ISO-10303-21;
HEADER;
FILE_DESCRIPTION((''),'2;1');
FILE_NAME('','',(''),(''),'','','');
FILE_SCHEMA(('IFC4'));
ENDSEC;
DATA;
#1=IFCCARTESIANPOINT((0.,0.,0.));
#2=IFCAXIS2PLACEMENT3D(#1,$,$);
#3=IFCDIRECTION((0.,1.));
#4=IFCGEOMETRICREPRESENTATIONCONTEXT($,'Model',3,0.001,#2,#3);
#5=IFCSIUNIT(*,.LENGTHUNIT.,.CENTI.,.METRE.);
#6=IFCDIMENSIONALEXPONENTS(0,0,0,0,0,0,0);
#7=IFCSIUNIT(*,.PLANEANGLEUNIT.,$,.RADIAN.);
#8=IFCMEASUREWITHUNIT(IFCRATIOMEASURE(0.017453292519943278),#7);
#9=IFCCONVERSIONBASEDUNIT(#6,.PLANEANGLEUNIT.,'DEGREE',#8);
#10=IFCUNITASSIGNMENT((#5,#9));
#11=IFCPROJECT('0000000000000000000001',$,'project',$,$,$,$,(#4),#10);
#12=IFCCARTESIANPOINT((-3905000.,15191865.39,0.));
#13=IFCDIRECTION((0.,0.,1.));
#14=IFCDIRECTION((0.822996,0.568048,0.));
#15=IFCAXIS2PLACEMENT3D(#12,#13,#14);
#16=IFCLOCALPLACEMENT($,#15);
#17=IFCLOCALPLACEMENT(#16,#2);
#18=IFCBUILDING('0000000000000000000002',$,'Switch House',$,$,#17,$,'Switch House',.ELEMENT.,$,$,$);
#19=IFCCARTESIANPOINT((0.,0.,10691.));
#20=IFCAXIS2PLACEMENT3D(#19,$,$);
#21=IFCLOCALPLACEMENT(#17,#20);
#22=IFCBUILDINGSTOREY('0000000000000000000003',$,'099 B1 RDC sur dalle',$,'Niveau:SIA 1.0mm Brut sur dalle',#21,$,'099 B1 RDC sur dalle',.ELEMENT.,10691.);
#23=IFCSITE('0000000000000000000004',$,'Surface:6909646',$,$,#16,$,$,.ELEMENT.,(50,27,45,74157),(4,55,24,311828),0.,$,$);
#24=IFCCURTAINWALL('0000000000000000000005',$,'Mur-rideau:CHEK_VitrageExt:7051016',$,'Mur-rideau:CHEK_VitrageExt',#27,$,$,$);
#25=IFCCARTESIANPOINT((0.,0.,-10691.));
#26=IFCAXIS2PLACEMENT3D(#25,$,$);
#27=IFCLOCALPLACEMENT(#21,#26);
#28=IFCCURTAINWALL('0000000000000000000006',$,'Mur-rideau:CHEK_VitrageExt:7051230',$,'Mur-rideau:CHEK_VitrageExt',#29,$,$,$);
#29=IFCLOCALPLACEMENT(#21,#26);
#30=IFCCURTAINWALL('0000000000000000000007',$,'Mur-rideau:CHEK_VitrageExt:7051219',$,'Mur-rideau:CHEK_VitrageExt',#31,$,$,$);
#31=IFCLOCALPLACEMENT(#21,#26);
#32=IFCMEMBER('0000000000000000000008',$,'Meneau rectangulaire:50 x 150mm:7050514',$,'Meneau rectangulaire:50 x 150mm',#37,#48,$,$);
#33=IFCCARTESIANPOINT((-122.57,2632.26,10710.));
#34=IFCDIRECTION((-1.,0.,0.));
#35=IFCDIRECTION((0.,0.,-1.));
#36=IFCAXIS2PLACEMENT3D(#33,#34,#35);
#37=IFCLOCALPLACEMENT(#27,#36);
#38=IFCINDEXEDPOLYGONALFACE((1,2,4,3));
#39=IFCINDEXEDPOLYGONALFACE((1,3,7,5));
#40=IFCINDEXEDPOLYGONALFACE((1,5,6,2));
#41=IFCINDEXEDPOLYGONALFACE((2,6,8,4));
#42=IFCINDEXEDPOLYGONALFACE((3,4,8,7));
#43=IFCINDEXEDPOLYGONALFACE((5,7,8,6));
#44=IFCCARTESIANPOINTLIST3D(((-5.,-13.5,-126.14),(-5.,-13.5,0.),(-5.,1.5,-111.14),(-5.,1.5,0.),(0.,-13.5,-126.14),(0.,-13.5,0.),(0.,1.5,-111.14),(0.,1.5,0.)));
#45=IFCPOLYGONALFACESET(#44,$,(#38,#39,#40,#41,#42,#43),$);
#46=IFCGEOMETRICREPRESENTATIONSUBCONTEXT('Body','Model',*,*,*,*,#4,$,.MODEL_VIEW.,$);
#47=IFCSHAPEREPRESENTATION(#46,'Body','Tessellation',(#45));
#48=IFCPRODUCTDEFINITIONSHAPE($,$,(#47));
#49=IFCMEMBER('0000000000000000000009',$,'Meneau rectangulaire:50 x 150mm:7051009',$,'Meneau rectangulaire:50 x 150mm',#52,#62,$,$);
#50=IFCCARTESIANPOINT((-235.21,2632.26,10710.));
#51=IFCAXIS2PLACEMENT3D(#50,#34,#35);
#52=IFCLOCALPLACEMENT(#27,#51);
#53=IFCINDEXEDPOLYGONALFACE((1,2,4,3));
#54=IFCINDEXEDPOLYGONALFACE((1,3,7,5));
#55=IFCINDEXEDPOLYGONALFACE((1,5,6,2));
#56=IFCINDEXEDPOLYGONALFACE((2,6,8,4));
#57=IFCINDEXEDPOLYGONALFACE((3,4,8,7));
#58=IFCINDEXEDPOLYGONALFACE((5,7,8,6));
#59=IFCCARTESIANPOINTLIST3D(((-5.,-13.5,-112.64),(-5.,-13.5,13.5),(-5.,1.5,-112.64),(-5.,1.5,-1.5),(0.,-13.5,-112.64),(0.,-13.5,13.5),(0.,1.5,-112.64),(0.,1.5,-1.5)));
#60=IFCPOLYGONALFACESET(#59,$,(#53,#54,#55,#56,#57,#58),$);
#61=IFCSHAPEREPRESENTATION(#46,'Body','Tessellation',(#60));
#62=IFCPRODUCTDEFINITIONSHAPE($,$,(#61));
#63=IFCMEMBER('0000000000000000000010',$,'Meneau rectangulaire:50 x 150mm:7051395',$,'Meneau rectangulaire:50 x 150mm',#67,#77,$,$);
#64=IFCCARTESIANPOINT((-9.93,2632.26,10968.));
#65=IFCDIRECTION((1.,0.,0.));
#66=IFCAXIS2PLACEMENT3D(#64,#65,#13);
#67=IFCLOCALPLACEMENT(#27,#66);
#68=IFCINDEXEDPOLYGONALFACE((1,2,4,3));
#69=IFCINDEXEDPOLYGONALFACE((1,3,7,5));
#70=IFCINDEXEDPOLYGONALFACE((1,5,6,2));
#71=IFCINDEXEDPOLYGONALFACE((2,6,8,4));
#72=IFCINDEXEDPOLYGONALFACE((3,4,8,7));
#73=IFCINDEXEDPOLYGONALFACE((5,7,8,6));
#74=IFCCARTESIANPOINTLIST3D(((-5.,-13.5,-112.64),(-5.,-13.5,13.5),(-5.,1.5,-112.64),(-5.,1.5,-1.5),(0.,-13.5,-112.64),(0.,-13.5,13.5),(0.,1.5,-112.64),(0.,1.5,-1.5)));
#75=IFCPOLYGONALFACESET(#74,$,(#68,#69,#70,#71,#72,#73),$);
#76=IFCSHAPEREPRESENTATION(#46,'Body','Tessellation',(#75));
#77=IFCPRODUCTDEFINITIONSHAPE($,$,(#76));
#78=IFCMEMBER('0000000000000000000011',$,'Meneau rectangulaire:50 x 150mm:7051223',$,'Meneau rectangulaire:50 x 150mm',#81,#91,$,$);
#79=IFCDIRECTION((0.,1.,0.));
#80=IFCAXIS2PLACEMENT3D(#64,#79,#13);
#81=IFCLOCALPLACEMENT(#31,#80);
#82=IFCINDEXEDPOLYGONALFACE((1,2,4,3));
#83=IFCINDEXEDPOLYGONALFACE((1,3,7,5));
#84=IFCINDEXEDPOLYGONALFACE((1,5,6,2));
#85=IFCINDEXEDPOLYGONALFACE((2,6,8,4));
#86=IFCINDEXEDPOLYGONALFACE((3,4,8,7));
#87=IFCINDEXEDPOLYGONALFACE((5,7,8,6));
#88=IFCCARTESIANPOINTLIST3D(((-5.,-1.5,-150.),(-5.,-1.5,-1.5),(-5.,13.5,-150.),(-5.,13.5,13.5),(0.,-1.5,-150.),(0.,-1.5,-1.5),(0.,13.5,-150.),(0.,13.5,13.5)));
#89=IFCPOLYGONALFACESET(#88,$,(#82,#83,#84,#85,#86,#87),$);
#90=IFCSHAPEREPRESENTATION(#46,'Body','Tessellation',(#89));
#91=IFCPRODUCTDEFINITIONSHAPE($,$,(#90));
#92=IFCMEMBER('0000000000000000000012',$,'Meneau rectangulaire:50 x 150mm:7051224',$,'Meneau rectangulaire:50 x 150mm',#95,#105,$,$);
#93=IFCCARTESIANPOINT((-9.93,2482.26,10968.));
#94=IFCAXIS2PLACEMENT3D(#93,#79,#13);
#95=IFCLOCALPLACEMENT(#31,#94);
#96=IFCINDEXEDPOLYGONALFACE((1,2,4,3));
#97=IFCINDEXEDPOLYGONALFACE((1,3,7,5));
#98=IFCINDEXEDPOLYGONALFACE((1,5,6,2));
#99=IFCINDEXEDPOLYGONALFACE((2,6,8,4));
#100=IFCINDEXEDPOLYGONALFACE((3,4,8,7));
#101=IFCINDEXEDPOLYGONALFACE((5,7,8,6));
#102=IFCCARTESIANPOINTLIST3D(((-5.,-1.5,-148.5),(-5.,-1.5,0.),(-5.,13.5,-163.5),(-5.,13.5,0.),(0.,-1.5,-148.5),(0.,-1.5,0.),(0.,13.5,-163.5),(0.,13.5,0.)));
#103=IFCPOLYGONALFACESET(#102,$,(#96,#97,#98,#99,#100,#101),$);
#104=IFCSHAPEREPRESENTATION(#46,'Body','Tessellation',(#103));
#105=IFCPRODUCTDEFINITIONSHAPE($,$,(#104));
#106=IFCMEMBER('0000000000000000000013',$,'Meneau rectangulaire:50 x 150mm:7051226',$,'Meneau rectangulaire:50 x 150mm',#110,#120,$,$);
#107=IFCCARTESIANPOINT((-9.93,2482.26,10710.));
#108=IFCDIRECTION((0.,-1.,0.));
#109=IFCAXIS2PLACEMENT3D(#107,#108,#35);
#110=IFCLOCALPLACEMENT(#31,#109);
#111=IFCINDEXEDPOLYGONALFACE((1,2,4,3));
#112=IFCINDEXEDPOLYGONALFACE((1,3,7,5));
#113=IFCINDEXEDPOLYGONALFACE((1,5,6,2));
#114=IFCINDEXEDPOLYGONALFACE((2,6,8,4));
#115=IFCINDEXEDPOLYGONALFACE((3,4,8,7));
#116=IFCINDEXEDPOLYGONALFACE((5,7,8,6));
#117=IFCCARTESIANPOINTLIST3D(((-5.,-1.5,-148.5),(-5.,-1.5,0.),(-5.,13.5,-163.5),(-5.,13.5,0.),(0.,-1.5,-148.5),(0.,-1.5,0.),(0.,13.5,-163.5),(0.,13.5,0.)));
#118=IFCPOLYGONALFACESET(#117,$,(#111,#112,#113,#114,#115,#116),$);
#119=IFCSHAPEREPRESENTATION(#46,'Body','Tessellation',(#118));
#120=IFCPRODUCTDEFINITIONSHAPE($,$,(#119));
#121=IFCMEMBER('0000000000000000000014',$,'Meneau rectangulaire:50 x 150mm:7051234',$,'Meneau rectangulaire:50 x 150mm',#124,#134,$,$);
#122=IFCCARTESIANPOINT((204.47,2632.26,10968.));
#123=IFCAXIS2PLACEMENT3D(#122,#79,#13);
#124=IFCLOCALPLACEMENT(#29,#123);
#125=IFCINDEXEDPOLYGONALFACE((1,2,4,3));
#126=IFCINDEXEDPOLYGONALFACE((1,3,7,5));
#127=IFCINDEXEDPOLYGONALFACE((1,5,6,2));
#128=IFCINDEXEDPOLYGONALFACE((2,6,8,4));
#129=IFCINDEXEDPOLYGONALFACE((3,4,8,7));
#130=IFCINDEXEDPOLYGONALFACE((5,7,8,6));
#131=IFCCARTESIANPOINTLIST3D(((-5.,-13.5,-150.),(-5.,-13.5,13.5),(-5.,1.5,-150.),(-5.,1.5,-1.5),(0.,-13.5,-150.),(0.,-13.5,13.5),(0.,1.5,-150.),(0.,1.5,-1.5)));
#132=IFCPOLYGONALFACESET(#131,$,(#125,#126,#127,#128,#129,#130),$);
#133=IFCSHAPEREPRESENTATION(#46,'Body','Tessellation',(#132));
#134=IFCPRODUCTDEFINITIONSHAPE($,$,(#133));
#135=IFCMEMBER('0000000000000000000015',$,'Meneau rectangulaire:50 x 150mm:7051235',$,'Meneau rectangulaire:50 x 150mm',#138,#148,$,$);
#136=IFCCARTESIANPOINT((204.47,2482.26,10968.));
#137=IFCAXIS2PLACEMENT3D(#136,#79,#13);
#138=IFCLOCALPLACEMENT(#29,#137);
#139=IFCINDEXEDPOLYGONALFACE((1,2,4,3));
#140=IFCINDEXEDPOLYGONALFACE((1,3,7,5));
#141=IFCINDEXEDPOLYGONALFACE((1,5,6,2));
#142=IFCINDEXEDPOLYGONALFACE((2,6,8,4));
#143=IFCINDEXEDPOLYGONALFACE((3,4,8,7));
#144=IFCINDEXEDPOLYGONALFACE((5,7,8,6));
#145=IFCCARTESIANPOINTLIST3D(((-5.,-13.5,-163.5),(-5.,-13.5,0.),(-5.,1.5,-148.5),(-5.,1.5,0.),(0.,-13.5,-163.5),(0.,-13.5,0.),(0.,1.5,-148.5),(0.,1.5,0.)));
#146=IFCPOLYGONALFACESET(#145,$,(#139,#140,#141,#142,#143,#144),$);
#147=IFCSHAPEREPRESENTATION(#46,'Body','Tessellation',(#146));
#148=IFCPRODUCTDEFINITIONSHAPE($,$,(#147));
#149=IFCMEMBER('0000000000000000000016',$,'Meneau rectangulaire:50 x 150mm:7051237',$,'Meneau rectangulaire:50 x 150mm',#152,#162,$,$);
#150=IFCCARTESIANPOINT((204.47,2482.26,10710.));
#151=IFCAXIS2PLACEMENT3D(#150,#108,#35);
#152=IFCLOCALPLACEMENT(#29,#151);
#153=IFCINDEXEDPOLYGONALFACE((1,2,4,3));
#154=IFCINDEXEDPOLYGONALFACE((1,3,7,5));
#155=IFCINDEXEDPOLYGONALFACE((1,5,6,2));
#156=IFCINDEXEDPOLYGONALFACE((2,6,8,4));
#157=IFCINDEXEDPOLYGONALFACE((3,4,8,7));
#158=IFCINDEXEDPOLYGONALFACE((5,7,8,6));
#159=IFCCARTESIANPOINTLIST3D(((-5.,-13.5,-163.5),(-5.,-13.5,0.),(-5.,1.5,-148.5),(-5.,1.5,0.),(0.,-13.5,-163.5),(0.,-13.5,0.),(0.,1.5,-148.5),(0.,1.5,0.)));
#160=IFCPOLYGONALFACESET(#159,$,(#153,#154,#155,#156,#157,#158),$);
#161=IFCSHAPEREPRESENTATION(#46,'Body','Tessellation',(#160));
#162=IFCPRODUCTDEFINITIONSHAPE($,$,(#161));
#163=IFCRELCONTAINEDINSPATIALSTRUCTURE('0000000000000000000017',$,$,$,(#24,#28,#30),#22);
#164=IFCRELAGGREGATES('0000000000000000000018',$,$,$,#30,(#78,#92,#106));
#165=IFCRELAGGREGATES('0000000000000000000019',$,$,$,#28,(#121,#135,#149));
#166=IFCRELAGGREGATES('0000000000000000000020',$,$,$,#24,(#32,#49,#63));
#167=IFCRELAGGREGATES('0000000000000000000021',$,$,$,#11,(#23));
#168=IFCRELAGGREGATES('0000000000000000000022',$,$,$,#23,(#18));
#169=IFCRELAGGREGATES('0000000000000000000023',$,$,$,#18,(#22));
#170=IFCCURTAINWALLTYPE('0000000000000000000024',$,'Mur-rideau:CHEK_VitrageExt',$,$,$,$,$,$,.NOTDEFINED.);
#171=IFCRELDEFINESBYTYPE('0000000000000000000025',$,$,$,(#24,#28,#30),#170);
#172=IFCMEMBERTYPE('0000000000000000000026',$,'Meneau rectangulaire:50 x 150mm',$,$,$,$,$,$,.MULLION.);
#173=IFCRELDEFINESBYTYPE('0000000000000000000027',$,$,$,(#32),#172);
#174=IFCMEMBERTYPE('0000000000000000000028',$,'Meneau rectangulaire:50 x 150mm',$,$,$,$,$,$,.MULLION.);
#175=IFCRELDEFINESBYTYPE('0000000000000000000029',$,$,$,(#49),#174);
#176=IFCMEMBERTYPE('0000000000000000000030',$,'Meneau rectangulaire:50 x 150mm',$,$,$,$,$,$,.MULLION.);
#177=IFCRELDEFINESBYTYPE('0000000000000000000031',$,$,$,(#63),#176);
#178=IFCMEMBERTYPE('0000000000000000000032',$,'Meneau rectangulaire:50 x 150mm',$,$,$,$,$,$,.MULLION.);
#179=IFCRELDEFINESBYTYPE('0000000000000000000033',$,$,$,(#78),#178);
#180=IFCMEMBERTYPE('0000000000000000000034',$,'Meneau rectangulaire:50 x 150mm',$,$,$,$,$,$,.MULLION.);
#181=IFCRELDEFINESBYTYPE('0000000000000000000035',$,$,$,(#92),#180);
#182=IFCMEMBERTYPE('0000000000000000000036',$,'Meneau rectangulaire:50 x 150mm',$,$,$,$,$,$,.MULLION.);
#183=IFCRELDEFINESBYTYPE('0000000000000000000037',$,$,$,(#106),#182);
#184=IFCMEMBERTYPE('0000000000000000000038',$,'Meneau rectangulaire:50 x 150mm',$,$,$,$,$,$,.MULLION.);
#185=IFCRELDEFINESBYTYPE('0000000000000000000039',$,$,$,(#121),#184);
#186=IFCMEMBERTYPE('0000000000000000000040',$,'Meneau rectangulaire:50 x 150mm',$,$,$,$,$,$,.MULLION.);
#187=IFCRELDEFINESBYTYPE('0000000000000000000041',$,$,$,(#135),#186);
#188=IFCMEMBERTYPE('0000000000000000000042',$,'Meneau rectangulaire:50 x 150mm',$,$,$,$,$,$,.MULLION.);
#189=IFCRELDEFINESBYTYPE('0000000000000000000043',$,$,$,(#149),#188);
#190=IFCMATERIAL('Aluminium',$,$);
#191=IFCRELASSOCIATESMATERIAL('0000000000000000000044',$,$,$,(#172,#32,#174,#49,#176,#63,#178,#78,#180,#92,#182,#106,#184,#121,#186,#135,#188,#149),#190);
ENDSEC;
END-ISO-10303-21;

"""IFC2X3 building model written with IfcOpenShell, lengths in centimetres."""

from ifc_helpers import new_model, entity, si_unit, converted_unit, direction, frame, origin, origin_2d_with_axis, place, context, subcontext, project, spatial, rectangle, extrude, clip, halfspace, source, transform, mapped, material, type_object, type_shapes, element, aggregate, save


model = new_model("IFC2X3")

# Units and contexts
model_context = context("Model", 3, precision=0.001, world=origin(), true_north=direction((0.0, 1.0)))
body_context = subcontext(model_context, "Body", "Model", "MODEL_VIEW")
ifc_project = project(units=[si_unit("LENGTHUNIT", "METRE", prefix="CENTI"), converted_unit("PLANEANGLEUNIT", "DEGREE", entity("IfcRatioMeasure", 0.017453292519943278), si_unit("PLANEANGLEUNIT", "RADIAN"), dimensions=[0, 0, 0, 0, 0, 0, 0])], contexts=[model_context])

# Site, building, storey
site_placement = place(None, frame((-3905000.0, 15191865.39, 0.0), z_axis=(0.0, 0.0, 1.0), x_axis=(0.822996, 0.568048, 0.0)))
site = spatial("IfcSite", under=ifc_project, at=site_placement, Name="Surface:6909646", CompositionType="ELEMENT", RefLatitude=(50, 27, 45, 74157), RefLongitude=(4, 55, 24, 311828), RefElevation=0.0)
building_placement = place(site_placement, origin())
building = spatial("IfcBuilding", under=site, at=building_placement, Name="Switch House", LongName="Switch House", CompositionType="ELEMENT")
storey_placement = place(building_placement, frame((0.0, 0.0, 10691.0)))
storey = spatial("IfcBuildingStorey", under=building, at=storey_placement, Name="099 B1 RDC sur dalle", ObjectType="Niveau:SIA 1.0mm Brut sur dalle", LongName="099 B1 RDC sur dalle", CompositionType="ELEMENT", Elevation=10691.0)

# Curtain wall
curtain_wall_type = type_object("IfcCurtainWallType", Name="Mur-rideau:CHEK_VitrageExt", PredefinedType="NOTDEFINED")
curtain_wall_1_placement = place(storey_placement, frame((0.0, 0.0, -10691.0)))
curtain_wall_1 = element("IfcCurtainWall", 1, at=curtain_wall_1_placement, inside=storey, type_object=curtain_wall_type, Name="Mur-rideau:CHEK_VitrageExt:7051016", ObjectType="Mur-rideau:CHEK_VitrageExt")
ifc_material_1 = material(Name="Aluminium")

# Curtain wall
curtain_wall_2_placement = place(storey_placement, frame((0.0, 0.0, -10691.0)))
curtain_wall_2 = element("IfcCurtainWall", 2, at=curtain_wall_2_placement, inside=storey, type_object=curtain_wall_type, Name="Mur-rideau:CHEK_VitrageExt:7051230", ObjectType="Mur-rideau:CHEK_VitrageExt")

# Curtain wall
curtain_wall_3_placement = place(storey_placement, frame((0.0, 0.0, -10691.0)))
curtain_wall_3 = element("IfcCurtainWall", 3, at=curtain_wall_3_placement, inside=storey, type_object=curtain_wall_type, Name="Mur-rideau:CHEK_VitrageExt:7051219", ObjectType="Mur-rideau:CHEK_VitrageExt")

# Members
member_type_1 = type_object("IfcMemberType", Name="Meneau rectangulaire:50 x 150mm", PredefinedType="MULLION", material=ifc_material_1)
shared_shape_1 = source(origin(), body_context, "Body", "SweptSolid", [
    clip(extrude(rectangle(XDim=15.0, YDim=5.0, at=origin_2d_with_axis()), frame((-2.5, -6.0, -126.14), z_axis=(0.0, 0.0, 1.0), x_axis=(0.0, -1.0, 0.0)), (0.0, 0.0, 1.0), 126.14), halfspace(frame((-30.48, 0.0, -112.64), z_axis=(0.0, 0.707107, -0.707107), x_axis=(0.0, 0.707107, 0.707107)), False)),
])
type_shapes(member_type_1, [shared_shape_1])
member_1_placement = place(curtain_wall_1_placement, frame((-122.57, 2632.26, 10710.0), z_axis=(-1.0, 0.0, 0.0), x_axis=(0.0, 0.0, -1.0)))
member_1 = element("IfcMember", 4, at=member_1_placement, type_object=member_type_1, material=ifc_material_1, Name="Meneau rectangulaire:50 x 150mm:7050514", ObjectType="Meneau rectangulaire:50 x 150mm", context=body_context, shape_type="MappedRepresentation", body=[
    mapped(shared_shape_1, transform((0.0, 0.0, 0.0), scale=1.0)),
])
member_type_2 = type_object("IfcMemberType", Name="Meneau rectangulaire:50 x 150mm", PredefinedType="MULLION", material=ifc_material_1)
shared_shape_2 = source(origin(), body_context, "Body", "SweptSolid", [
    clip(extrude(rectangle(XDim=15.0, YDim=5.0, at=origin_2d_with_axis()), frame((-2.5, -6.0, -112.64), z_axis=(0.0, 0.0, 1.0), x_axis=(0.0, -1.0, 0.0)), (0.0, 0.0, 1.0), 126.14), halfspace(frame((-30.48, 0.0, 0.0), z_axis=(0.0, 0.707107, 0.707107), x_axis=(0.0, 0.707107, -0.707107)), False)),
])
type_shapes(member_type_2, [shared_shape_2])
member_2_placement = place(curtain_wall_1_placement, frame((-235.21, 2632.26, 10710.0), z_axis=(-1.0, 0.0, 0.0), x_axis=(0.0, 0.0, -1.0)))
member_2 = element("IfcMember", 5, at=member_2_placement, type_object=member_type_2, material=ifc_material_1, Name="Meneau rectangulaire:50 x 150mm:7051009", ObjectType="Meneau rectangulaire:50 x 150mm", context=body_context, shape_type="MappedRepresentation", body=[
    mapped(shared_shape_2, transform((0.0, 0.0, 0.0), scale=1.0)),
])
member_type_3 = type_object("IfcMemberType", Name="Meneau rectangulaire:50 x 150mm", PredefinedType="MULLION", material=ifc_material_1)
shared_shape_3 = source(origin(), body_context, "Body", "SweptSolid", [
    clip(extrude(rectangle(XDim=15.0, YDim=5.0, at=origin_2d_with_axis()), frame((-2.5, -6.0, -112.64), z_axis=(0.0, 0.0, 1.0), x_axis=(0.0, -1.0, 0.0)), (0.0, 0.0, 1.0), 126.14), halfspace(frame((-30.48, 0.0, 0.0), z_axis=(0.0, 0.707107, 0.707107), x_axis=(0.0, 0.707107, -0.707107)), False)),
])
type_shapes(member_type_3, [shared_shape_3])
member_3_placement = place(curtain_wall_1_placement, frame((-9.93, 2632.26, 10968.0), z_axis=(1.0, 0.0, 0.0), x_axis=(0.0, 0.0, 1.0)))
member_3 = element("IfcMember", 6, at=member_3_placement, type_object=member_type_3, material=ifc_material_1, Name="Meneau rectangulaire:50 x 150mm:7051395", ObjectType="Meneau rectangulaire:50 x 150mm", context=body_context, shape_type="MappedRepresentation", body=[
    mapped(shared_shape_3, transform((0.0, 0.0, 0.0), scale=1.0)),
])
member_type_4 = type_object("IfcMemberType", Name="Meneau rectangulaire:50 x 150mm", PredefinedType="MULLION", material=ifc_material_1)
shared_shape_4 = source(origin(), body_context, "Body", "SweptSolid", [
    clip(extrude(rectangle(XDim=15.0, YDim=5.0, at=origin_2d_with_axis()), frame((-2.5, 6.0, -150.0), z_axis=(0.0, 0.0, 1.0), x_axis=(0.0, -1.0, 0.0)), (0.0, 0.0, 1.0), 163.5), halfspace(frame((30.48, 0.0, 0.0), z_axis=(0.0, -0.707107, 0.707107), x_axis=(0.0, -0.707107, -0.707107)), False)),
])
type_shapes(member_type_4, [shared_shape_4])
member_4_placement = place(curtain_wall_3_placement, frame((-9.93, 2632.26, 10968.0), z_axis=(0.0, 1.0, 0.0), x_axis=(0.0, 0.0, 1.0)))
member_4 = element("IfcMember", 7, at=member_4_placement, type_object=member_type_4, material=ifc_material_1, Name="Meneau rectangulaire:50 x 150mm:7051223", ObjectType="Meneau rectangulaire:50 x 150mm", context=body_context, shape_type="MappedRepresentation", body=[
    mapped(shared_shape_4, transform((0.0, 0.0, 0.0), scale=1.0)),
])
member_type_5 = type_object("IfcMemberType", Name="Meneau rectangulaire:50 x 150mm", PredefinedType="MULLION", material=ifc_material_1)
shared_shape_5 = source(origin(), body_context, "Body", "SweptSolid", [
    clip(extrude(rectangle(XDim=15.0, YDim=5.0, at=origin_2d_with_axis()), frame((-2.5, 6.0, -163.5), z_axis=(0.0, 0.0, 1.0), x_axis=(0.0, -1.0, 0.0)), (0.0, 0.0, 1.0), 163.5), halfspace(frame((30.48, 0.0, -150.0), z_axis=(0.0, -0.707107, -0.707107), x_axis=(0.0, -0.707107, 0.707107)), False)),
])
type_shapes(member_type_5, [shared_shape_5])
member_5_placement = place(curtain_wall_3_placement, frame((-9.93, 2482.26, 10968.0), z_axis=(0.0, 1.0, 0.0), x_axis=(0.0, 0.0, 1.0)))
member_5 = element("IfcMember", 8, at=member_5_placement, type_object=member_type_5, material=ifc_material_1, Name="Meneau rectangulaire:50 x 150mm:7051224", ObjectType="Meneau rectangulaire:50 x 150mm", context=body_context, shape_type="MappedRepresentation", body=[
    mapped(shared_shape_5, transform((0.0, 0.0, 0.0), scale=1.0)),
])
member_type_6 = type_object("IfcMemberType", Name="Meneau rectangulaire:50 x 150mm", PredefinedType="MULLION", material=ifc_material_1)
shared_shape_6 = source(origin(), body_context, "Body", "SweptSolid", [
    clip(extrude(rectangle(XDim=15.0, YDim=5.0, at=origin_2d_with_axis()), frame((-2.5, 6.0, -163.5), z_axis=(0.0, 0.0, 1.0), x_axis=(0.0, -1.0, 0.0)), (0.0, 0.0, 1.0), 163.5), halfspace(frame((30.48, 0.0, -150.0), z_axis=(0.0, -0.707107, -0.707107), x_axis=(0.0, -0.707107, 0.707107)), False)),
])
type_shapes(member_type_6, [shared_shape_6])
member_6_placement = place(curtain_wall_3_placement, frame((-9.93, 2482.26, 10710.0), z_axis=(0.0, -1.0, 0.0), x_axis=(0.0, 0.0, -1.0)))
member_6 = element("IfcMember", 9, at=member_6_placement, type_object=member_type_6, material=ifc_material_1, Name="Meneau rectangulaire:50 x 150mm:7051226", ObjectType="Meneau rectangulaire:50 x 150mm", context=body_context, shape_type="MappedRepresentation", body=[
    mapped(shared_shape_6, transform((0.0, 0.0, 0.0), scale=1.0)),
])
member_type_7 = type_object("IfcMemberType", Name="Meneau rectangulaire:50 x 150mm", PredefinedType="MULLION", material=ifc_material_1)
shared_shape_7 = source(origin(), body_context, "Body", "SweptSolid", [
    clip(extrude(rectangle(XDim=15.0, YDim=5.0, at=origin_2d_with_axis()), frame((-2.5, -6.0, -150.0), z_axis=(0.0, 0.0, 1.0), x_axis=(0.0, -1.0, 0.0)), (0.0, 0.0, 1.0), 163.5), halfspace(frame((-30.48, 0.0, 0.0), z_axis=(0.0, 0.707107, 0.707107), x_axis=(0.0, 0.707107, -0.707107)), False)),
])
type_shapes(member_type_7, [shared_shape_7])
member_7_placement = place(curtain_wall_2_placement, frame((204.47, 2632.26, 10968.0), z_axis=(0.0, 1.0, 0.0), x_axis=(0.0, 0.0, 1.0)))
member_7 = element("IfcMember", 10, at=member_7_placement, type_object=member_type_7, material=ifc_material_1, Name="Meneau rectangulaire:50 x 150mm:7051234", ObjectType="Meneau rectangulaire:50 x 150mm", context=body_context, shape_type="MappedRepresentation", body=[
    mapped(shared_shape_7, transform((0.0, 0.0, 0.0), scale=1.0)),
])
member_type_8 = type_object("IfcMemberType", Name="Meneau rectangulaire:50 x 150mm", PredefinedType="MULLION", material=ifc_material_1)
shared_shape_8 = source(origin(), body_context, "Body", "SweptSolid", [
    clip(extrude(rectangle(XDim=15.0, YDim=5.0, at=origin_2d_with_axis()), frame((-2.5, -6.0, -163.5), z_axis=(0.0, 0.0, 1.0), x_axis=(0.0, -1.0, 0.0)), (0.0, 0.0, 1.0), 163.5), halfspace(frame((-30.48, 0.0, -150.0), z_axis=(0.0, 0.707107, -0.707107), x_axis=(0.0, 0.707107, 0.707107)), False)),
])
type_shapes(member_type_8, [shared_shape_8])
member_8_placement = place(curtain_wall_2_placement, frame((204.47, 2482.26, 10968.0), z_axis=(0.0, 1.0, 0.0), x_axis=(0.0, 0.0, 1.0)))
member_8 = element("IfcMember", 11, at=member_8_placement, type_object=member_type_8, material=ifc_material_1, Name="Meneau rectangulaire:50 x 150mm:7051235", ObjectType="Meneau rectangulaire:50 x 150mm", context=body_context, shape_type="MappedRepresentation", body=[
    mapped(shared_shape_8, transform((0.0, 0.0, 0.0), scale=1.0)),
])
member_type_9 = type_object("IfcMemberType", Name="Meneau rectangulaire:50 x 150mm", PredefinedType="MULLION", material=ifc_material_1)
shared_shape_9 = source(origin(), body_context, "Body", "SweptSolid", [
    clip(extrude(rectangle(XDim=15.0, YDim=5.0, at=origin_2d_with_axis()), frame((-2.5, -6.0, -163.5), z_axis=(0.0, 0.0, 1.0), x_axis=(0.0, -1.0, 0.0)), (0.0, 0.0, 1.0), 163.5), halfspace(frame((-30.48, 0.0, -150.0), z_axis=(0.0, 0.707107, -0.707107), x_axis=(0.0, 0.707107, 0.707107)), False)),
])
type_shapes(member_type_9, [shared_shape_9])
member_9_placement = place(curtain_wall_2_placement, frame((204.47, 2482.26, 10710.0), z_axis=(0.0, -1.0, 0.0), x_axis=(0.0, 0.0, -1.0)))
member_9 = element("IfcMember", 12, at=member_9_placement, type_object=member_type_9, material=ifc_material_1, Name="Meneau rectangulaire:50 x 150mm:7051237", ObjectType="Meneau rectangulaire:50 x 150mm", context=body_context, shape_type="MappedRepresentation", body=[
    mapped(shared_shape_9, transform((0.0, 0.0, 0.0), scale=1.0)),
])

aggregate(curtain_wall_3, [member_4, member_5, member_6])
aggregate(curtain_wall_2, [member_7, member_8, member_9])
aggregate(curtain_wall_1, [member_1, member_2, member_3])

save(model, "model.ifc")
